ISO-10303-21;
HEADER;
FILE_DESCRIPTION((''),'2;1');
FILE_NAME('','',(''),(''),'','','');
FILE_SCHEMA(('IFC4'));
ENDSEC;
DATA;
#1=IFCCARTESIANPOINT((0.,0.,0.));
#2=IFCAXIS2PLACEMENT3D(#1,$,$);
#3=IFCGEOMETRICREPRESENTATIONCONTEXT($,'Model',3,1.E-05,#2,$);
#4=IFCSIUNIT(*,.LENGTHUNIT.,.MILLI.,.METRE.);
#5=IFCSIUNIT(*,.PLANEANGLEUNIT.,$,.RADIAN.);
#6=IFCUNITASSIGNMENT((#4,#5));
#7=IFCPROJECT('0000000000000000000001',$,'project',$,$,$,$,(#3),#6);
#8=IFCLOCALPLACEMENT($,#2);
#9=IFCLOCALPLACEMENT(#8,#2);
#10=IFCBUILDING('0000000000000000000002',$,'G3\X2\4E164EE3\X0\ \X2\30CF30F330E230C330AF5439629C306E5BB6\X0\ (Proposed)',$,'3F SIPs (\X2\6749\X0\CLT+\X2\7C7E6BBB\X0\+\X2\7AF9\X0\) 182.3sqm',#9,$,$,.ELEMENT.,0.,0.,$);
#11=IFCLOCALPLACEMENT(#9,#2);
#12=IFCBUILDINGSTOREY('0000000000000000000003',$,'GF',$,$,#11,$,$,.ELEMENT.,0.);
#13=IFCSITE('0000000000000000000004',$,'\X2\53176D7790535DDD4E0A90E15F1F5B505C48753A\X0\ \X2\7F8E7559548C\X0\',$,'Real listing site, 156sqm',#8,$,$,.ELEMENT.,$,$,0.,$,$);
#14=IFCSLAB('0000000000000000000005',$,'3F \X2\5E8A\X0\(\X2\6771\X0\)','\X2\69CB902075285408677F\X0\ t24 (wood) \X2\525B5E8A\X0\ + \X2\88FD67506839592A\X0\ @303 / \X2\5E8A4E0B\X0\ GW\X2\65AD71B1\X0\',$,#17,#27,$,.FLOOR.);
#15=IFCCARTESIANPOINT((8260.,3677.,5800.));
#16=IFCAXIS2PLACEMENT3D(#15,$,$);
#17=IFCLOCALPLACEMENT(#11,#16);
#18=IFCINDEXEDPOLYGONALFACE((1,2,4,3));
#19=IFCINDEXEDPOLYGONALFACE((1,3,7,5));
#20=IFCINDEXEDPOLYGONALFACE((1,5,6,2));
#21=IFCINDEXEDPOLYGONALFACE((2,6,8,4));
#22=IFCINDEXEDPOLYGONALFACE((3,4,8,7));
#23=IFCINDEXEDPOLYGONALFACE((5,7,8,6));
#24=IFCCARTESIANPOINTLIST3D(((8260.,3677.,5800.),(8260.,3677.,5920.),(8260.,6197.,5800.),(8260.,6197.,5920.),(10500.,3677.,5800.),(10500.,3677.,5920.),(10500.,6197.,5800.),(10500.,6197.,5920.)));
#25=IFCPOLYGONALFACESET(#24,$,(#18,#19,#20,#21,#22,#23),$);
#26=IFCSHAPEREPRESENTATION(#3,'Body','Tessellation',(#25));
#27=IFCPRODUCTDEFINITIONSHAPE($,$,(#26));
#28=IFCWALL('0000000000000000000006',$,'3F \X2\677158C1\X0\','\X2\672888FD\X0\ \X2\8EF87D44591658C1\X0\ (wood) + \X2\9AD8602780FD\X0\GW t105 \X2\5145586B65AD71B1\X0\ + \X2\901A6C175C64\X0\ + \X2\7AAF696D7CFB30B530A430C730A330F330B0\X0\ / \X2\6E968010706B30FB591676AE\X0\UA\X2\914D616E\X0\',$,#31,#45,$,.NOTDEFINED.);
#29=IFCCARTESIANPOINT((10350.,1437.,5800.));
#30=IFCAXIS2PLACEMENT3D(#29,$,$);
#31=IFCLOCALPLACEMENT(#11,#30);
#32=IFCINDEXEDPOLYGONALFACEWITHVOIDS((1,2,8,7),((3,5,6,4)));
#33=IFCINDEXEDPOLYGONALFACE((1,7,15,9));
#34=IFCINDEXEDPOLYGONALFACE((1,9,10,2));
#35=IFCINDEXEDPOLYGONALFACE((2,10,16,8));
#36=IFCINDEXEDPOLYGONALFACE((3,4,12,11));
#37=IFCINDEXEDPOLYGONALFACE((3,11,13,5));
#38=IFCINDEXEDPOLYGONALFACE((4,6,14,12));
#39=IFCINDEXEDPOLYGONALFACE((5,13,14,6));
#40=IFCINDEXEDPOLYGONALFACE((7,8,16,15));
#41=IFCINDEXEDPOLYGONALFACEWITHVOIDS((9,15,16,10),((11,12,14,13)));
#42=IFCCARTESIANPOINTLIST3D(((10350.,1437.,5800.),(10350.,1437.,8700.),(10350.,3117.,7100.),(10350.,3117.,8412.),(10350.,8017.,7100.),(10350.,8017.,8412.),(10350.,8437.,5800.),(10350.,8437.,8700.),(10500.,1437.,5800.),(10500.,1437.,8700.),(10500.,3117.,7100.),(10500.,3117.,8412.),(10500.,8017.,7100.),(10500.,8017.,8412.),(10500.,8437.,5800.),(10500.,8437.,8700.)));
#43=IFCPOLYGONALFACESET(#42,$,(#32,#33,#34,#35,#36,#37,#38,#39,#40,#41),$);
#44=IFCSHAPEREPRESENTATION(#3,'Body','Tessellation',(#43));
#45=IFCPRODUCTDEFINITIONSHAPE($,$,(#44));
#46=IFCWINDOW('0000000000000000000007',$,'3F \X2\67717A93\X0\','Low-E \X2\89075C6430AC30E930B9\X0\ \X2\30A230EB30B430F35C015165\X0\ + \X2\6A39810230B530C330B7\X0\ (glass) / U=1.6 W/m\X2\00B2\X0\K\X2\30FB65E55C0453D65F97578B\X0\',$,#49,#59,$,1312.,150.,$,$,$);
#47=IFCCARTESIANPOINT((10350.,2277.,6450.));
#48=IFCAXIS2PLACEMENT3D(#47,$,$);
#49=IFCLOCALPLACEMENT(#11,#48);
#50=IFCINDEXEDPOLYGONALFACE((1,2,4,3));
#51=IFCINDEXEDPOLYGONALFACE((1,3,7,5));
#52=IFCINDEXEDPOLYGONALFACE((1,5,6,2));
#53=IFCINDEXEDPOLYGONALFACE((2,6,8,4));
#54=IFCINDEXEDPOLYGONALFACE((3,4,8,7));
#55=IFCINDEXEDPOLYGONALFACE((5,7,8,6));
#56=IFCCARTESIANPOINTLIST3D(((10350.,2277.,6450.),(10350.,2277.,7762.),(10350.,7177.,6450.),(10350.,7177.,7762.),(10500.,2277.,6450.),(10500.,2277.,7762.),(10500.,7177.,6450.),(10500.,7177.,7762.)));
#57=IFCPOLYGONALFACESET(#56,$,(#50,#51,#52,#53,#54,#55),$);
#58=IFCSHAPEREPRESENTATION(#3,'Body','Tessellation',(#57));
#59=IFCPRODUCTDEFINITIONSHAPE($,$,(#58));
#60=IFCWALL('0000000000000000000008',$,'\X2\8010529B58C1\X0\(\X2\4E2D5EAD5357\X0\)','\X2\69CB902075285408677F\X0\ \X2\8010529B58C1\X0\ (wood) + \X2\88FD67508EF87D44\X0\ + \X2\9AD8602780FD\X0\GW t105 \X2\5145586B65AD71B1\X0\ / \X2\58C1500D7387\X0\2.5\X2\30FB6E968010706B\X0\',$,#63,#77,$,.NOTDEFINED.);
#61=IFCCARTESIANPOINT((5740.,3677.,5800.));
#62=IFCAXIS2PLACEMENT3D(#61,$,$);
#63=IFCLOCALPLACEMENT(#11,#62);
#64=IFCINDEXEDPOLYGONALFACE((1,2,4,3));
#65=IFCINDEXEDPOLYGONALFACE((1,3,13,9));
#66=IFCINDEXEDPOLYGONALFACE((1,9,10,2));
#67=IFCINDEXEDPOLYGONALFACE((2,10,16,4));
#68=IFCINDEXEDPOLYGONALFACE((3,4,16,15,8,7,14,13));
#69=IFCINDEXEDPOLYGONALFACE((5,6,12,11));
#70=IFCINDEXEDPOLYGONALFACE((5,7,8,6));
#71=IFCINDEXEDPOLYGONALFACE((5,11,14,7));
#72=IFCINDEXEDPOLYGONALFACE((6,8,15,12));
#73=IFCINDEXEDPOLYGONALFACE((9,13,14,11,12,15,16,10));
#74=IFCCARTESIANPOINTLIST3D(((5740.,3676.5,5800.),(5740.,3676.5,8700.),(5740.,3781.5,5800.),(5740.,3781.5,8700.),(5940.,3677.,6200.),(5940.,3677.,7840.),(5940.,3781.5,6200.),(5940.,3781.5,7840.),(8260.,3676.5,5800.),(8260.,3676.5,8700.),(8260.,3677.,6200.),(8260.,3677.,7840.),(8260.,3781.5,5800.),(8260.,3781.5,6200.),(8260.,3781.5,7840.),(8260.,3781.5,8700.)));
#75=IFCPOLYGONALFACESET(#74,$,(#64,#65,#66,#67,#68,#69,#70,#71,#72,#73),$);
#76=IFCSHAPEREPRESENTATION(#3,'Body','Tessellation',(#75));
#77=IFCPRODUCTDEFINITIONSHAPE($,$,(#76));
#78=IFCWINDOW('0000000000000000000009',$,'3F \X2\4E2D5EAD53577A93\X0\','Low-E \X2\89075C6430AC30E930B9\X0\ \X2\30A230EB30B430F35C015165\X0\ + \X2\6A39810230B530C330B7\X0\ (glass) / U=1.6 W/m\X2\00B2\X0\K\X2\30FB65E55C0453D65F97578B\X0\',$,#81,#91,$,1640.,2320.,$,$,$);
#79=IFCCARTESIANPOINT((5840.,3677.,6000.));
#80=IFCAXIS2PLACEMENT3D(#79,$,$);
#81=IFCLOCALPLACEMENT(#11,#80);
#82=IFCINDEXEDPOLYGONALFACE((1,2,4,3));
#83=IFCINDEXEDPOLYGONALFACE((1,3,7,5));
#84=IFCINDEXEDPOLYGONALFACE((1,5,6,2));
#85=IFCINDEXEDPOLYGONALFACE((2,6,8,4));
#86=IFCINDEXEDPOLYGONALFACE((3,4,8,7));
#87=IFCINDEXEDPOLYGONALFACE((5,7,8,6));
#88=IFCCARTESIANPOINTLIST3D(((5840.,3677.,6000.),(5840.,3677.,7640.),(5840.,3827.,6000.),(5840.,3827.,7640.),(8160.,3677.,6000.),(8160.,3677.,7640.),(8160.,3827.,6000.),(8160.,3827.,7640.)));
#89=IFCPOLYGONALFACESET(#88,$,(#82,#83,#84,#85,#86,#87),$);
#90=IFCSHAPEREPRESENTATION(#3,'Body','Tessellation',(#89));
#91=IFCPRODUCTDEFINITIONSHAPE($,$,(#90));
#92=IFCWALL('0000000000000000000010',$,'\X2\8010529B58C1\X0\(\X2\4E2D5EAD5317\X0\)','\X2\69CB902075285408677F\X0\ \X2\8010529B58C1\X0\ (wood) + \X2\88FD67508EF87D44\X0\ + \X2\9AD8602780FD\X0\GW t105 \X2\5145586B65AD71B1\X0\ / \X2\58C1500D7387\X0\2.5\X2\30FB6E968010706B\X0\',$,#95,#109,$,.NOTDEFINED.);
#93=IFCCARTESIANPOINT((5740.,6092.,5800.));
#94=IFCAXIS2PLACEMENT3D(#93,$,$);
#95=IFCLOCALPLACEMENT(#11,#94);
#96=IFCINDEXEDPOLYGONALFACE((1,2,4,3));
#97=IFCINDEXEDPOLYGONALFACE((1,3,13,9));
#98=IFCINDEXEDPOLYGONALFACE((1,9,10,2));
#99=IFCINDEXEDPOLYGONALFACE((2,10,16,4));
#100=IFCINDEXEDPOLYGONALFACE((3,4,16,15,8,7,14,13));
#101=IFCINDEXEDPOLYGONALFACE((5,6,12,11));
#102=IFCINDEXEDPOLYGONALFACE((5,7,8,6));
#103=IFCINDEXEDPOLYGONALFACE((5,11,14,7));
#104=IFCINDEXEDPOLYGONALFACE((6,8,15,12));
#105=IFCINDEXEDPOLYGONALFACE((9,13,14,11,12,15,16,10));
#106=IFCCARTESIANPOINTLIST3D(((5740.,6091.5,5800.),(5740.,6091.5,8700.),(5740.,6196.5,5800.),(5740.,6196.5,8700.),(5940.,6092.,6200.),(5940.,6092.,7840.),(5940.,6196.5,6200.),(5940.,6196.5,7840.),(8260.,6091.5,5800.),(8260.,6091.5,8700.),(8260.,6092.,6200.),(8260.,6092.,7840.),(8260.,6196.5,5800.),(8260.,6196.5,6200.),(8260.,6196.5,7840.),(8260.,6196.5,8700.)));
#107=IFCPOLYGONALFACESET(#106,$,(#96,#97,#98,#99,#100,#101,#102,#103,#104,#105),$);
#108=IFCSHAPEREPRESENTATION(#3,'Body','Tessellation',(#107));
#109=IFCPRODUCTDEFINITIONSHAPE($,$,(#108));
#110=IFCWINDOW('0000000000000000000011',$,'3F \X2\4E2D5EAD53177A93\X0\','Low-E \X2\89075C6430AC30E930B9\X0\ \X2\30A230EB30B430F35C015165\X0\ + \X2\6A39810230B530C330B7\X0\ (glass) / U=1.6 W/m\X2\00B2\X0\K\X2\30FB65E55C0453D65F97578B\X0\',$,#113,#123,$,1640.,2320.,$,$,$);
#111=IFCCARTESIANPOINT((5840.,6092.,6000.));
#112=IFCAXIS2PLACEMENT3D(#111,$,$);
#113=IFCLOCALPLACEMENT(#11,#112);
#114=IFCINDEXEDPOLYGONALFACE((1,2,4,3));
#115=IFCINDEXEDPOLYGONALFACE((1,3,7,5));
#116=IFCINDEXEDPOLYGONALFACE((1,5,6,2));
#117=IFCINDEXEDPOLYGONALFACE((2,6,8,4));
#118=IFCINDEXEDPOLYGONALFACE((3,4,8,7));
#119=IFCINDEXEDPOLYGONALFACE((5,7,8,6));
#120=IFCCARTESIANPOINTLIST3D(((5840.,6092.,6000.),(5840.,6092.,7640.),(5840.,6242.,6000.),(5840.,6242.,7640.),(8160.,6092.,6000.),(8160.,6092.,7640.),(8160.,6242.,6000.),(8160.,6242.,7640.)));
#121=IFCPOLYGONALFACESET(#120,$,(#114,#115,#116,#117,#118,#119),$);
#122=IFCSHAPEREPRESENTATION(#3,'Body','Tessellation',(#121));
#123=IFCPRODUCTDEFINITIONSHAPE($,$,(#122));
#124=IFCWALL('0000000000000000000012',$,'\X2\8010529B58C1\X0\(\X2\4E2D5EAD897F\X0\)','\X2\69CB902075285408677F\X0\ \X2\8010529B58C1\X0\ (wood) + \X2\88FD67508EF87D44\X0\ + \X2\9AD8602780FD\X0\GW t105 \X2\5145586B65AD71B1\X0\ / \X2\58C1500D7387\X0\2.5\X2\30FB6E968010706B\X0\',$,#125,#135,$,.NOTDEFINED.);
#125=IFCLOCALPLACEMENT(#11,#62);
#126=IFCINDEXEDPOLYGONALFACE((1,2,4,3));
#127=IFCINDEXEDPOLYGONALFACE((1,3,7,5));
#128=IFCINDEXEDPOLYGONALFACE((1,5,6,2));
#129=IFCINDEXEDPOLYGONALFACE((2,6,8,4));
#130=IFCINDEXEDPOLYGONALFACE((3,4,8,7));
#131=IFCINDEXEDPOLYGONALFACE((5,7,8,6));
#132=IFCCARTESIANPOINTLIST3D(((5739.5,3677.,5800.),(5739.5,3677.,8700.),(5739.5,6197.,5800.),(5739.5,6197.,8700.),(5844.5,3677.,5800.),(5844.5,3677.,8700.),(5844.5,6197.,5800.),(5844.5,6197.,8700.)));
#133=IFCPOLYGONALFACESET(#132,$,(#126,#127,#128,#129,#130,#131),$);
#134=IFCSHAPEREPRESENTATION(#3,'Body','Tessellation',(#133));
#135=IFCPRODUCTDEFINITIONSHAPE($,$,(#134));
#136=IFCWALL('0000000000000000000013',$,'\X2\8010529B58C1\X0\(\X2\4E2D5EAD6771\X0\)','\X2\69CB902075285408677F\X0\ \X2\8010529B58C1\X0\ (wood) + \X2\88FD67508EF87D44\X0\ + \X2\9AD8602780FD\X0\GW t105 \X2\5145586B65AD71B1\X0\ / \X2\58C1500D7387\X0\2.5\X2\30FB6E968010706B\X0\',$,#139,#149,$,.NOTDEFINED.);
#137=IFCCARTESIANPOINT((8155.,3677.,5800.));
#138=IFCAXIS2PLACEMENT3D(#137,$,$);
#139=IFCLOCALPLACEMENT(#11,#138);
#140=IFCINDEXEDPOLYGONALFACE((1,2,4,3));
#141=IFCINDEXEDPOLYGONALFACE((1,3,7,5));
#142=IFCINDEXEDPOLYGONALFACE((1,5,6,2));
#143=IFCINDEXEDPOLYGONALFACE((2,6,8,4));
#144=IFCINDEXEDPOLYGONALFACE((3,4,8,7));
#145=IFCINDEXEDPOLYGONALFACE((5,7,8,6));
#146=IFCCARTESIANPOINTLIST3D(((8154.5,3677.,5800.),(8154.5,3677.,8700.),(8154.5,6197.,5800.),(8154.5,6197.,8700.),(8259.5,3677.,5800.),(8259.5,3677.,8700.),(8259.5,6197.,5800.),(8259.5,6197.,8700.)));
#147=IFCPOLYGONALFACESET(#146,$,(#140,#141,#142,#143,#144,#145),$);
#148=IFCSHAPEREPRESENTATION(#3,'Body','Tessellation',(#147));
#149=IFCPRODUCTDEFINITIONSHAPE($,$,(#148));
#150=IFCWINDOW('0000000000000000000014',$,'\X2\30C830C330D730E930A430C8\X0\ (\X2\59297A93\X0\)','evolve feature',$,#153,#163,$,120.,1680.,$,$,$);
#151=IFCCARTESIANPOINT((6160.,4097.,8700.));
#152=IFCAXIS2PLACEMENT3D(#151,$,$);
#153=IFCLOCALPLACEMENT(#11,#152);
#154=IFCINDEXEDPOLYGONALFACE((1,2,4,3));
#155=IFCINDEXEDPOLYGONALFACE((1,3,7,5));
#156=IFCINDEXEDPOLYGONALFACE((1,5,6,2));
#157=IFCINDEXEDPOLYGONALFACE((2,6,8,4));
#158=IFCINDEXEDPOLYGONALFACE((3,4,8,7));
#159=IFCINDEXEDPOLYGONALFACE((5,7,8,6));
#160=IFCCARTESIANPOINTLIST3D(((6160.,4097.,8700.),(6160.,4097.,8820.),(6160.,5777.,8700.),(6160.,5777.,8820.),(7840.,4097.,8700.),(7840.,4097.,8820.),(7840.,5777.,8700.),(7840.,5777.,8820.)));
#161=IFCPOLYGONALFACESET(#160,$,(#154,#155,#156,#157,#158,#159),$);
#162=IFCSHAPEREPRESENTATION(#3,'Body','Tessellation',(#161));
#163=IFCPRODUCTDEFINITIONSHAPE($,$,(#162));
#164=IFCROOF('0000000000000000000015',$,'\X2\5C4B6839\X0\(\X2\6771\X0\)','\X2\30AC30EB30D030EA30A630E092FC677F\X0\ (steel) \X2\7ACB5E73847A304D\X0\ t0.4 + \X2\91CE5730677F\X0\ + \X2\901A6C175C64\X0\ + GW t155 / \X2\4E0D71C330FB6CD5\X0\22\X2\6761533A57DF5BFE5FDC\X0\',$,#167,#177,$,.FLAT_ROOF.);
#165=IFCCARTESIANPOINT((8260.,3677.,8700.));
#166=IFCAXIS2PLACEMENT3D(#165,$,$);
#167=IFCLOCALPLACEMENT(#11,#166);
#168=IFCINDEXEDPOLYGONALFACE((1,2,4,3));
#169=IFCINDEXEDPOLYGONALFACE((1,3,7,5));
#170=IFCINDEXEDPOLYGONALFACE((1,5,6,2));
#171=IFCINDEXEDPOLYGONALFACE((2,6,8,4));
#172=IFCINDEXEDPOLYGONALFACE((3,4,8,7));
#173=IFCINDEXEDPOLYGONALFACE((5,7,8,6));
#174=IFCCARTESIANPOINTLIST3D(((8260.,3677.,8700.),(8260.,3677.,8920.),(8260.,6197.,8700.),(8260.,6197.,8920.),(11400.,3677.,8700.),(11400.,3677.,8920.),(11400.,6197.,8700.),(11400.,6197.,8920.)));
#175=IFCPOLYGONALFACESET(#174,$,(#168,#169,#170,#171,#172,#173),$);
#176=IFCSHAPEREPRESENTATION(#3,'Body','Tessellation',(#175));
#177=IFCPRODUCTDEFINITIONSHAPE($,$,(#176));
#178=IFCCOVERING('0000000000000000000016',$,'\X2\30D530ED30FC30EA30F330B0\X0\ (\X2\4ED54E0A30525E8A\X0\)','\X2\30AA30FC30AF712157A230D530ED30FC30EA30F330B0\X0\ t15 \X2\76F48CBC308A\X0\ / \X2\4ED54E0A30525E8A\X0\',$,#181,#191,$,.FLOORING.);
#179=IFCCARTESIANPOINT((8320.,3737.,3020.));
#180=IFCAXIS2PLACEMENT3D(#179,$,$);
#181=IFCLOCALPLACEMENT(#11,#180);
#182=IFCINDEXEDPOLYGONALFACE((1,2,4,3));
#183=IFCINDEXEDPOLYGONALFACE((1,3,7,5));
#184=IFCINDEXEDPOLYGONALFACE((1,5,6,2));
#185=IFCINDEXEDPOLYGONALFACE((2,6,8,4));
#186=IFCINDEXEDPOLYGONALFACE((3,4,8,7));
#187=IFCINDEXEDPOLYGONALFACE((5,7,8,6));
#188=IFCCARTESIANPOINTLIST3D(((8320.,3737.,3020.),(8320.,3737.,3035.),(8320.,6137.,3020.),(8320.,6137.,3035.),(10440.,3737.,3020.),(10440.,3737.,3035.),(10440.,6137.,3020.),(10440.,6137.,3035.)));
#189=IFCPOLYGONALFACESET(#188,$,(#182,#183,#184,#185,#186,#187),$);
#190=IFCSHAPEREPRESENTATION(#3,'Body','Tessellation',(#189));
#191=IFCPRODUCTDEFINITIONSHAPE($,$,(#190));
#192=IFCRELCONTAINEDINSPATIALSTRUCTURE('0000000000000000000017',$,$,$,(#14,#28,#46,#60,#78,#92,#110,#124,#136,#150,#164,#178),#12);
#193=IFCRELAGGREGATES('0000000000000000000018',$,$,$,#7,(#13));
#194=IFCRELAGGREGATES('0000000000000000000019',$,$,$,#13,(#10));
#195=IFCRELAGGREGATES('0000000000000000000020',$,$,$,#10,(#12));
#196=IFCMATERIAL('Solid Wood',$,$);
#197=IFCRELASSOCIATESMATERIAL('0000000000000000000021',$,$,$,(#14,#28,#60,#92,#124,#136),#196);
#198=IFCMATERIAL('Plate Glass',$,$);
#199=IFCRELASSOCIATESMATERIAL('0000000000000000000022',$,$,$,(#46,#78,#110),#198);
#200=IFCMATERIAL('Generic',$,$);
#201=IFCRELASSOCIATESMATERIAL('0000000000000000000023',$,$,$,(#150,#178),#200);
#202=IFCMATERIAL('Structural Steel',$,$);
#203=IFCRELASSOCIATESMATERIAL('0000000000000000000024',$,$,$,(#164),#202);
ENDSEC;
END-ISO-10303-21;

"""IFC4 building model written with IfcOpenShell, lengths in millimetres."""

from ifc_helpers import new_model, si_unit, frame, frame_2d, origin, place, context, project, spatial, rectangle, extrude, material, element, fill, save


model = new_model("IFC4")

# Units and contexts
model_context = context("Model", 3, precision=1e-05, world=origin())
ifc_project = project(units=[si_unit("LENGTHUNIT", "METRE", prefix="MILLI"), si_unit("PLANEANGLEUNIT", "RADIAN")], contexts=[model_context])

# Site, building, storey
site_placement = place(None, origin())
site = spatial("IfcSite", under=ifc_project, at=site_placement, Name="北海道川上郡弟子屈町 美留和", ObjectType="Real listing site, 156sqm", CompositionType="ELEMENT", RefElevation=0.0)
building_placement = place(site_placement, origin())
building = spatial("IfcBuilding", under=site, at=building_placement, Name="G3世代 ハンモック吹抜の家 (Proposed)", ObjectType="3F SIPs (杉CLT+籾殻+竹) 182.3sqm", CompositionType="ELEMENT", ElevationOfRefHeight=0.0, ElevationOfTerrain=0.0)
storey_placement = place(building_placement, origin())
storey = spatial("IfcBuildingStorey", under=building, at=storey_placement, Name="GF", CompositionType="ELEMENT", Elevation=0.0)

# Slab
ifc_material_1 = material(Name="Solid Wood")
slab_placement = place(storey_placement, frame((8260.0, 3677.0, 5800.0)))
element("IfcSlab", 1, at=slab_placement, inside=storey, material=ifc_material_1, Name="3F 床(東)", Description="構造用合板 t24 (wood) 剛床 + 製材根太 @303 / 床下 GW断熱", PredefinedType="FLOOR", context=model_context, shape_type="SweptSolid", body=[
    extrude(rectangle(XDim=2240.0, YDim=2520.0, at=frame_2d((1120.0, 1260.0))), frame((8260.0, 3677.0, 5800.0)), (0.0, 0.0, 1.0), 120.0),
])

# Walls, openings, windows
wall_1_placement = place(storey_placement, frame((10350.0, 1437.0, 5800.0)))
wall_1 = element("IfcWall", 2, at=wall_1_placement, inside=storey, material=ifc_material_1, Name="3F 東壁", Description="木製 軸組外壁 (wood) + 高性能GW t105 充填断熱 + 通気層 + 窯業系サイディング / 準耐火・外皮UA配慮", PredefinedType="NOTDEFINED", context=model_context, shape_type="SweptSolid", body=[
    extrude(rectangle(XDim=150.0, YDim=7000.0, at=frame_2d((75.0, 3500.0))), frame((10350.0, 1437.0, 5800.0)), (0.0, 0.0, 1.0), 2900.0),
])
opening_1_placement = place(storey_placement, frame((10350.0, 2277.0, 6450.0)))
opening_1 = element("IfcOpeningElement", 3, at=opening_1_placement, cuts=wall_1, PredefinedType="NOTDEFINED", context=model_context, shape_type="SweptSolid", body=[
    extrude(rectangle(XDim=150.0, YDim=4900.0, at=frame_2d((75.0, 2450.0))), frame((10350.0, 2277.0, 6450.0)), (0.0, 0.0, 1.0), 1312.0),
])
ifc_material_2 = material(Name="Plate Glass")
window_1_placement = place(storey_placement, frame((10350.0, 2277.0, 6450.0)))
window_1 = element("IfcWindow", 4, at=window_1_placement, inside=storey, material=ifc_material_2, Name="3F 東窓", Description="Low-E 複層ガラス アルゴン封入 + 樹脂サッシ (glass) / U=1.6 W/m²K・日射取得型", OverallHeight=1312.0, OverallWidth=150.0, context=model_context, shape_type="SweptSolid", body=[
    extrude(rectangle(XDim=150.0, YDim=4900.0, at=frame_2d((75.0, 2450.0))), frame((10350.0, 2277.0, 6450.0)), (0.0, 0.0, 1.0), 1312.0),
])
fill(opening_1, window_1)
wall_2_placement = place(storey_placement, frame((5740.0, 3677.0, 5800.0)))
wall_2 = element("IfcWall", 5, at=wall_2_placement, inside=storey, material=ifc_material_1, Name="耐力壁(中庭南)", Description="構造用合板 耐力壁 (wood) + 製材軸組 + 高性能GW t105 充填断熱 / 壁倍率2.5・準耐火", PredefinedType="NOTDEFINED", context=model_context, shape_type="SweptSolid", body=[
    extrude(rectangle(XDim=2520.0, YDim=105.0, at=frame_2d((1260.0, 52.0))), frame((5740.0, 3677.0, 5800.0)), (0.0, 0.0, 1.0), 2900.0),
])
opening_2_placement = place(storey_placement, frame((5840.0, 3677.0, 6000.0)))
opening_2 = element("IfcOpeningElement", 6, at=opening_2_placement, cuts=wall_2, PredefinedType="NOTDEFINED", context=model_context, shape_type="SweptSolid", body=[
    extrude(rectangle(XDim=2320.0, YDim=150.0, at=frame_2d((1160.0, 75.0))), frame((5840.0, 3677.0, 6000.0)), (0.0, 0.0, 1.0), 1640.0),
])
window_2_placement = place(storey_placement, frame((5840.0, 3677.0, 6000.0)))
window_2 = element("IfcWindow", 7, at=window_2_placement, inside=storey, material=ifc_material_2, Name="3F 中庭南窓", Description="Low-E 複層ガラス アルゴン封入 + 樹脂サッシ (glass) / U=1.6 W/m²K・日射取得型", OverallHeight=1640.0, OverallWidth=2320.0, context=model_context, shape_type="SweptSolid", body=[
    extrude(rectangle(XDim=2320.0, YDim=150.0, at=frame_2d((1160.0, 75.0))), frame((5840.0, 3677.0, 6000.0)), (0.0, 0.0, 1.0), 1640.0),
])
fill(opening_2, window_2)
wall_3_placement = place(storey_placement, frame((5740.0, 6092.0, 5800.0)))
wall_3 = element("IfcWall", 8, at=wall_3_placement, inside=storey, material=ifc_material_1, Name="耐力壁(中庭北)", Description="構造用合板 耐力壁 (wood) + 製材軸組 + 高性能GW t105 充填断熱 / 壁倍率2.5・準耐火", PredefinedType="NOTDEFINED", context=model_context, shape_type="SweptSolid", body=[
    extrude(rectangle(XDim=2520.0, YDim=105.0, at=frame_2d((1260.0, 52.0))), frame((5740.0, 6092.0, 5800.0)), (0.0, 0.0, 1.0), 2900.0),
])
opening_3_placement = place(storey_placement, frame((5840.0, 6092.0, 6000.0)))
opening_3 = element("IfcOpeningElement", 9, at=opening_3_placement, cuts=wall_3, PredefinedType="NOTDEFINED", context=model_context, shape_type="SweptSolid", body=[
    extrude(rectangle(XDim=2320.0, YDim=150.0, at=frame_2d((1160.0, 75.0))), frame((5840.0, 6092.0, 6000.0)), (0.0, 0.0, 1.0), 1640.0),
])
window_3_placement = place(storey_placement, frame((5840.0, 6092.0, 6000.0)))
window_3 = element("IfcWindow", 10, at=window_3_placement, inside=storey, material=ifc_material_2, Name="3F 中庭北窓", Description="Low-E 複層ガラス アルゴン封入 + 樹脂サッシ (glass) / U=1.6 W/m²K・日射取得型", OverallHeight=1640.0, OverallWidth=2320.0, context=model_context, shape_type="SweptSolid", body=[
    extrude(rectangle(XDim=2320.0, YDim=150.0, at=frame_2d((1160.0, 75.0))), frame((5840.0, 6092.0, 6000.0)), (0.0, 0.0, 1.0), 1640.0),
])
fill(opening_3, window_3)

# Walls
wall_4_placement = place(storey_placement, frame((5740.0, 3677.0, 5800.0)))
element("IfcWall", 11, at=wall_4_placement, inside=storey, material=ifc_material_1, Name="耐力壁(中庭西)", Description="構造用合板 耐力壁 (wood) + 製材軸組 + 高性能GW t105 充填断熱 / 壁倍率2.5・準耐火", PredefinedType="NOTDEFINED", context=model_context, shape_type="SweptSolid", body=[
    extrude(rectangle(XDim=105.0, YDim=2520.0, at=frame_2d((52.0, 1260.0))), frame((5740.0, 3677.0, 5800.0)), (0.0, 0.0, 1.0), 2900.0),
])
wall_5_placement = place(storey_placement, frame((8155.0, 3677.0, 5800.0)))
element("IfcWall", 12, at=wall_5_placement, inside=storey, material=ifc_material_1, Name="耐力壁(中庭東)", Description="構造用合板 耐力壁 (wood) + 製材軸組 + 高性能GW t105 充填断熱 / 壁倍率2.5・準耐火", PredefinedType="NOTDEFINED", context=model_context, shape_type="SweptSolid", body=[
    extrude(rectangle(XDim=105.0, YDim=2520.0, at=frame_2d((52.0, 1260.0))), frame((8155.0, 3677.0, 5800.0)), (0.0, 0.0, 1.0), 2900.0),
])

# Window
ifc_material_3 = material(Name="Generic")
window_4_placement = place(storey_placement, frame((6160.0, 4097.0, 8700.0)))
element("IfcWindow", 13, at=window_4_placement, inside=storey, material=ifc_material_3, Name="トップライト (天窓)", Description="evolve feature", OverallHeight=120.0, OverallWidth=1680.0, context=model_context, shape_type="SweptSolid", body=[
    extrude(rectangle(XDim=1680.0, YDim=1680.0, at=frame_2d((840.0, 840.0))), frame((6160.0, 4097.0, 8700.0)), (0.0, 0.0, 1.0), 120.0),
])

# Roof
ifc_material_4 = material(Name="Structural Steel")
for number, where, name in (
    (14, (8260.0, 3677.0, 8700.0), "屋根(東)"),
):
    element("IfcRoof", number, at=place(storey_placement, frame(where)), inside=storey, material=ifc_material_4, Name=name, Description="ガルバリウム鋼板 (steel) 立平葺き t0.4 + 野地板 + 通気層 + GW t155 / 不燃・法22条区域対応", PredefinedType="FLAT_ROOF", context=model_context, shape_type="SweptSolid", body=[
        extrude(rectangle(XDim=3140.0, YDim=2520.0, at=frame_2d((1570.0, 1260.0))), frame((8260.0, 3677.0, 8700.0)), (0.0, 0.0, 1.0), 220.0),
    ])

# Covering
covering_1_placement = place(storey_placement, frame((8320.0, 3737.0, 3020.0)))
element("IfcCovering", 15, at=covering_1_placement, inside=storey, material=ifc_material_3, Name="フローリング (仕上げ床)", Description="オーク無垢フローリング t15 直貼り / 仕上げ床", PredefinedType="FLOORING", context=model_context, shape_type="SweptSolid", body=[
    extrude(rectangle(XDim=2120.0, YDim=2400.0, at=frame_2d((1060.0, 1200.0))), frame((8320.0, 3737.0, 3020.0)), (0.0, 0.0, 1.0), 15.0),
])

save(model, "model.ifc")
